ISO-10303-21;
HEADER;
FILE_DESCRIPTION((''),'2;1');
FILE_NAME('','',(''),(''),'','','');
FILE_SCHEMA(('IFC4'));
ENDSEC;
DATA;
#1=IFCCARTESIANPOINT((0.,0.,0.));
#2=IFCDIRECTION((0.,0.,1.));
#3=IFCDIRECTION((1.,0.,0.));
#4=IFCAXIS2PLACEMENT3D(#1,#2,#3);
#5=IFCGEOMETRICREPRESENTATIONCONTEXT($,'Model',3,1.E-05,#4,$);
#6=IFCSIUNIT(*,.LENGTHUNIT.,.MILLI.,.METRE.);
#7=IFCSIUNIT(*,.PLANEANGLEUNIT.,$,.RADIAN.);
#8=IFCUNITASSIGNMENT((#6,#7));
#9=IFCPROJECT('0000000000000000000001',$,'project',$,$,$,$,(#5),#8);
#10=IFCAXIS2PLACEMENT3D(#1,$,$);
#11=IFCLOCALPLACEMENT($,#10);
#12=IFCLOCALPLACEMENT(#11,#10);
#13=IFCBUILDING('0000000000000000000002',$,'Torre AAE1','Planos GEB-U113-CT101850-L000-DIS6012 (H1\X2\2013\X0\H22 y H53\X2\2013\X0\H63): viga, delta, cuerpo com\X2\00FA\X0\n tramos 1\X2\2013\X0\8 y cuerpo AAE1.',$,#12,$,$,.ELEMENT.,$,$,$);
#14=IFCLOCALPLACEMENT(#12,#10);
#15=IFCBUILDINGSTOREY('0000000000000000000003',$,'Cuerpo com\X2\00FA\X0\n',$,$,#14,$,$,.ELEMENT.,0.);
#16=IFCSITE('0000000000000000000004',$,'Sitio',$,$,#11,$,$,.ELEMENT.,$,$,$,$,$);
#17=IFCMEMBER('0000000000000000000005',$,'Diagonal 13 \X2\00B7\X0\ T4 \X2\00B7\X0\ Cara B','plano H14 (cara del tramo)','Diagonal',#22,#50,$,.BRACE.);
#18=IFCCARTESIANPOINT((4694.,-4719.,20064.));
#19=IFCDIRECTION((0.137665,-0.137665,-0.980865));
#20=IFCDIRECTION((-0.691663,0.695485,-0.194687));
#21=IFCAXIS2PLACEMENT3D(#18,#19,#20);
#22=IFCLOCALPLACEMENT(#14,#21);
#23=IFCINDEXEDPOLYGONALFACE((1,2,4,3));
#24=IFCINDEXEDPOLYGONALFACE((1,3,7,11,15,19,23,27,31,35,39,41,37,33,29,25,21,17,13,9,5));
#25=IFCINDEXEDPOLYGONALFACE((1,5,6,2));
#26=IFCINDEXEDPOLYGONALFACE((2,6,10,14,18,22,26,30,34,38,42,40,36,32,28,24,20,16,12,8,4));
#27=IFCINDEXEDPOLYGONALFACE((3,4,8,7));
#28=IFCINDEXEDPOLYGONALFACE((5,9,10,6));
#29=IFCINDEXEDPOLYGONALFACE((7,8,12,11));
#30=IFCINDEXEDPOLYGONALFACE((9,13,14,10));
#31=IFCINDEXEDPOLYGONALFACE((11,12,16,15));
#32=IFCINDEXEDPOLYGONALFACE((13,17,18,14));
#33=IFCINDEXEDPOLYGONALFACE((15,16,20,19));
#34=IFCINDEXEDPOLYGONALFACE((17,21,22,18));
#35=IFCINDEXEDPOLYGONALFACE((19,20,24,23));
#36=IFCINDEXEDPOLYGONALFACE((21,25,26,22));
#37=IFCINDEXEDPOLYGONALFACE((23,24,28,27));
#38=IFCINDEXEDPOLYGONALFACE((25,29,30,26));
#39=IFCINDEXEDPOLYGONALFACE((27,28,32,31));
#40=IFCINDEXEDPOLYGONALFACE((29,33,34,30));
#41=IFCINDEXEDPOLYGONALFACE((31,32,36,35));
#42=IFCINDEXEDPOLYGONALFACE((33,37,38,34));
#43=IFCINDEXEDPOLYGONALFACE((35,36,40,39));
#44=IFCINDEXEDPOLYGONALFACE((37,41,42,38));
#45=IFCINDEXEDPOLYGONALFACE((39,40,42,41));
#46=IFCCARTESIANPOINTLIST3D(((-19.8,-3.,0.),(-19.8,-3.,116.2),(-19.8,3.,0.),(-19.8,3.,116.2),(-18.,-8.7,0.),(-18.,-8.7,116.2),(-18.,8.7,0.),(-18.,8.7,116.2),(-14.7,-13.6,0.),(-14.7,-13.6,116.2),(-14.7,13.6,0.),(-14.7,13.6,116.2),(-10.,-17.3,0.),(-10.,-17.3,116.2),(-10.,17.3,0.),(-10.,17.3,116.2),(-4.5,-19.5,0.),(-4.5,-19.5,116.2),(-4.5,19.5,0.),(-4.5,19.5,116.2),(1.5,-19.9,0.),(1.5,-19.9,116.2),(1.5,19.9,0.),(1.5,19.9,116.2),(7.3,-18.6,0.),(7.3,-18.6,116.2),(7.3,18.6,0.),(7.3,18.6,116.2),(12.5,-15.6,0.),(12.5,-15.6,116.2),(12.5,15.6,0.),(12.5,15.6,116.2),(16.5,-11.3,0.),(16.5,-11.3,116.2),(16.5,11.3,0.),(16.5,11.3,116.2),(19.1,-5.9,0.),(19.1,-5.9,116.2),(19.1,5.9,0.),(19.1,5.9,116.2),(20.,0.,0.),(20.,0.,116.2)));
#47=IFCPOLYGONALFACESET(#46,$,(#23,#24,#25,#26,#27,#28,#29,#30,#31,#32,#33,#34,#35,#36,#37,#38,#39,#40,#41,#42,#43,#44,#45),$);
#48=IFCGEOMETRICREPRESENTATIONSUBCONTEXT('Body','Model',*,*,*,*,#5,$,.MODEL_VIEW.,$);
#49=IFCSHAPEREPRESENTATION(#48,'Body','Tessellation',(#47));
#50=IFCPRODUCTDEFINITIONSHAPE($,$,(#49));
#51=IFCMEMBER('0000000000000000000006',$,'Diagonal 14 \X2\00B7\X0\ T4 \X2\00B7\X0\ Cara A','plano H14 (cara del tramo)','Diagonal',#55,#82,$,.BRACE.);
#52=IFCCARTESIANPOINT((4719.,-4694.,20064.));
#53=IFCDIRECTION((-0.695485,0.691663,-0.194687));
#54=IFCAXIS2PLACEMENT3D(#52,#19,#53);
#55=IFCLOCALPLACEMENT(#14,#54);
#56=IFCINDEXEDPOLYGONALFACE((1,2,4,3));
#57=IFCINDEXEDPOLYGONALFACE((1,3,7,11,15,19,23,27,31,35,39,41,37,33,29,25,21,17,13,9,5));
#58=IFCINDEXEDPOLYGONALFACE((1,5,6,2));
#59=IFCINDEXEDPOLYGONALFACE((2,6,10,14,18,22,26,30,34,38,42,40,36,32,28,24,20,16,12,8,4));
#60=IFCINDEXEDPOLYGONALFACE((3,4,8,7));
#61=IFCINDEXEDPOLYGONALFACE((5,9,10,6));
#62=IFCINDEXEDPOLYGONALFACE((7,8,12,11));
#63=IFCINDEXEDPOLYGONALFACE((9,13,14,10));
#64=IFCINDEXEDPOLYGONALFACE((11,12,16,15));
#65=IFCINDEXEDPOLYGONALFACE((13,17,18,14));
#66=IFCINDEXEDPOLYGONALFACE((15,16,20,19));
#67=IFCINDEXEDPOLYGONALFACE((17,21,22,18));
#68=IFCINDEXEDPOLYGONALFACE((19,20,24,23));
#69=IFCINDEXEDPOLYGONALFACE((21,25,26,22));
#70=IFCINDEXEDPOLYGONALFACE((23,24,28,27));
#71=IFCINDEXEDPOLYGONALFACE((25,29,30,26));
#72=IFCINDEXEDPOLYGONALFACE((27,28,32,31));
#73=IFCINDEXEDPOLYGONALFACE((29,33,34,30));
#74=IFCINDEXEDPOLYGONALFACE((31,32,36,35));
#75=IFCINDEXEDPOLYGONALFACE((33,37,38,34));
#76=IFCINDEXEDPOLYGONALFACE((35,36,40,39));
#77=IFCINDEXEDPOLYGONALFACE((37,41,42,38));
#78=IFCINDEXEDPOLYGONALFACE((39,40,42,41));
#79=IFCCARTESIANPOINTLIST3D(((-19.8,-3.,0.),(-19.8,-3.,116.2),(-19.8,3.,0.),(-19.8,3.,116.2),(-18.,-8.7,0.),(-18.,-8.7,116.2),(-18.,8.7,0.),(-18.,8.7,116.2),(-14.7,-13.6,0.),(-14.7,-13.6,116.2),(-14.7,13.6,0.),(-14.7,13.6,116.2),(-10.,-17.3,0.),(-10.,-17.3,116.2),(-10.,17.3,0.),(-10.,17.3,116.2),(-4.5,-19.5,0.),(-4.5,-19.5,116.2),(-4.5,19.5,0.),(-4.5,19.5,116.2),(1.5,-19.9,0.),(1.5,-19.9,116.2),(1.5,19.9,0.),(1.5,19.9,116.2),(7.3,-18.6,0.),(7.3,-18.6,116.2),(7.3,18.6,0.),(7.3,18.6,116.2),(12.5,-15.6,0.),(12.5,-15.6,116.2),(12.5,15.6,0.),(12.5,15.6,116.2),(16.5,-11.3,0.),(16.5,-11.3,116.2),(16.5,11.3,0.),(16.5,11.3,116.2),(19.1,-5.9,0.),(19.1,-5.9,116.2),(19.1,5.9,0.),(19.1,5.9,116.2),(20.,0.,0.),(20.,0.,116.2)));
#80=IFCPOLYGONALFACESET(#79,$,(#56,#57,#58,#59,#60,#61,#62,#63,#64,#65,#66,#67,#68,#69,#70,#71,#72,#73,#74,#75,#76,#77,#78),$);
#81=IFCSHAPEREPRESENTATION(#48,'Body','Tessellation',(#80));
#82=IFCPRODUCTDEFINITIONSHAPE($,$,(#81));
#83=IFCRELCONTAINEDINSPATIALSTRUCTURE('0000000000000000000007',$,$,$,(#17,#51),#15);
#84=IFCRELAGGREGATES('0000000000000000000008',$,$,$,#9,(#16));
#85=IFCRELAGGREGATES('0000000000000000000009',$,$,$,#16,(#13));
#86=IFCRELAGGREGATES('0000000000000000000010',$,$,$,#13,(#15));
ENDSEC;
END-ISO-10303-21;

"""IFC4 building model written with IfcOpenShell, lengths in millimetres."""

from ifc_helpers import new_model, si_unit, frame, origin, origin_with_axes, place, context, subcontext, project, spatial, circle, extrude, element, save


model = new_model("IFC4")

# Units and contexts
model_context = context("Model", 3, precision=1e-05, world=origin_with_axes())
body_context = subcontext(model_context, "Body", "Model", "MODEL_VIEW")
ifc_project = project(units=[si_unit("LENGTHUNIT", "METRE", prefix="MILLI"), si_unit("PLANEANGLEUNIT", "RADIAN")], contexts=[model_context])

# Site, building, storey
site_placement = place(None, origin())
site = spatial("IfcSite", under=ifc_project, at=site_placement, Name="Sitio", CompositionType="ELEMENT")
building_placement = place(site_placement, origin())
building = spatial("IfcBuilding", under=site, at=building_placement, Name="Torre AAE1", Description="Planos GEB-U113-CT101850-L000-DIS6012 (H1–H22 y H53–H63): viga, delta, cuerpo común tramos 1–8 y cuerpo AAE1.", CompositionType="ELEMENT")
storey_placement = place(building_placement, origin())
storey = spatial("IfcBuildingStorey", under=building, at=storey_placement, Name="Cuerpo común", CompositionType="ELEMENT", Elevation=0.0)

# Members
for number, where, z_axis, x_axis, name in (
    (1, (4694.0, -4719.0, 20064.0), (0.137665, -0.137665, -0.980865), (-0.691663, 0.695485, -0.194687), "Diagonal 13 · T4 · Cara B"),
    (2, (4719.0, -4694.0, 20064.0), (0.137665, -0.137665, -0.980865), (-0.695485, 0.691663, -0.194687), "Diagonal 14 · T4 · Cara A"),
):
    element("IfcMember", number, at=place(storey_placement, frame(where, z_axis=z_axis, x_axis=x_axis)), inside=storey, Name=name, Description="plano H14 (cara del tramo)", ObjectType="Diagonal", PredefinedType="BRACE", context=body_context, shape_type="SweptSolid", body=[
        extrude(circle(Radius=20.0), None, (0.0, 0.0, 1.0), 116.2),
    ])

save(model, "model.ifc")
